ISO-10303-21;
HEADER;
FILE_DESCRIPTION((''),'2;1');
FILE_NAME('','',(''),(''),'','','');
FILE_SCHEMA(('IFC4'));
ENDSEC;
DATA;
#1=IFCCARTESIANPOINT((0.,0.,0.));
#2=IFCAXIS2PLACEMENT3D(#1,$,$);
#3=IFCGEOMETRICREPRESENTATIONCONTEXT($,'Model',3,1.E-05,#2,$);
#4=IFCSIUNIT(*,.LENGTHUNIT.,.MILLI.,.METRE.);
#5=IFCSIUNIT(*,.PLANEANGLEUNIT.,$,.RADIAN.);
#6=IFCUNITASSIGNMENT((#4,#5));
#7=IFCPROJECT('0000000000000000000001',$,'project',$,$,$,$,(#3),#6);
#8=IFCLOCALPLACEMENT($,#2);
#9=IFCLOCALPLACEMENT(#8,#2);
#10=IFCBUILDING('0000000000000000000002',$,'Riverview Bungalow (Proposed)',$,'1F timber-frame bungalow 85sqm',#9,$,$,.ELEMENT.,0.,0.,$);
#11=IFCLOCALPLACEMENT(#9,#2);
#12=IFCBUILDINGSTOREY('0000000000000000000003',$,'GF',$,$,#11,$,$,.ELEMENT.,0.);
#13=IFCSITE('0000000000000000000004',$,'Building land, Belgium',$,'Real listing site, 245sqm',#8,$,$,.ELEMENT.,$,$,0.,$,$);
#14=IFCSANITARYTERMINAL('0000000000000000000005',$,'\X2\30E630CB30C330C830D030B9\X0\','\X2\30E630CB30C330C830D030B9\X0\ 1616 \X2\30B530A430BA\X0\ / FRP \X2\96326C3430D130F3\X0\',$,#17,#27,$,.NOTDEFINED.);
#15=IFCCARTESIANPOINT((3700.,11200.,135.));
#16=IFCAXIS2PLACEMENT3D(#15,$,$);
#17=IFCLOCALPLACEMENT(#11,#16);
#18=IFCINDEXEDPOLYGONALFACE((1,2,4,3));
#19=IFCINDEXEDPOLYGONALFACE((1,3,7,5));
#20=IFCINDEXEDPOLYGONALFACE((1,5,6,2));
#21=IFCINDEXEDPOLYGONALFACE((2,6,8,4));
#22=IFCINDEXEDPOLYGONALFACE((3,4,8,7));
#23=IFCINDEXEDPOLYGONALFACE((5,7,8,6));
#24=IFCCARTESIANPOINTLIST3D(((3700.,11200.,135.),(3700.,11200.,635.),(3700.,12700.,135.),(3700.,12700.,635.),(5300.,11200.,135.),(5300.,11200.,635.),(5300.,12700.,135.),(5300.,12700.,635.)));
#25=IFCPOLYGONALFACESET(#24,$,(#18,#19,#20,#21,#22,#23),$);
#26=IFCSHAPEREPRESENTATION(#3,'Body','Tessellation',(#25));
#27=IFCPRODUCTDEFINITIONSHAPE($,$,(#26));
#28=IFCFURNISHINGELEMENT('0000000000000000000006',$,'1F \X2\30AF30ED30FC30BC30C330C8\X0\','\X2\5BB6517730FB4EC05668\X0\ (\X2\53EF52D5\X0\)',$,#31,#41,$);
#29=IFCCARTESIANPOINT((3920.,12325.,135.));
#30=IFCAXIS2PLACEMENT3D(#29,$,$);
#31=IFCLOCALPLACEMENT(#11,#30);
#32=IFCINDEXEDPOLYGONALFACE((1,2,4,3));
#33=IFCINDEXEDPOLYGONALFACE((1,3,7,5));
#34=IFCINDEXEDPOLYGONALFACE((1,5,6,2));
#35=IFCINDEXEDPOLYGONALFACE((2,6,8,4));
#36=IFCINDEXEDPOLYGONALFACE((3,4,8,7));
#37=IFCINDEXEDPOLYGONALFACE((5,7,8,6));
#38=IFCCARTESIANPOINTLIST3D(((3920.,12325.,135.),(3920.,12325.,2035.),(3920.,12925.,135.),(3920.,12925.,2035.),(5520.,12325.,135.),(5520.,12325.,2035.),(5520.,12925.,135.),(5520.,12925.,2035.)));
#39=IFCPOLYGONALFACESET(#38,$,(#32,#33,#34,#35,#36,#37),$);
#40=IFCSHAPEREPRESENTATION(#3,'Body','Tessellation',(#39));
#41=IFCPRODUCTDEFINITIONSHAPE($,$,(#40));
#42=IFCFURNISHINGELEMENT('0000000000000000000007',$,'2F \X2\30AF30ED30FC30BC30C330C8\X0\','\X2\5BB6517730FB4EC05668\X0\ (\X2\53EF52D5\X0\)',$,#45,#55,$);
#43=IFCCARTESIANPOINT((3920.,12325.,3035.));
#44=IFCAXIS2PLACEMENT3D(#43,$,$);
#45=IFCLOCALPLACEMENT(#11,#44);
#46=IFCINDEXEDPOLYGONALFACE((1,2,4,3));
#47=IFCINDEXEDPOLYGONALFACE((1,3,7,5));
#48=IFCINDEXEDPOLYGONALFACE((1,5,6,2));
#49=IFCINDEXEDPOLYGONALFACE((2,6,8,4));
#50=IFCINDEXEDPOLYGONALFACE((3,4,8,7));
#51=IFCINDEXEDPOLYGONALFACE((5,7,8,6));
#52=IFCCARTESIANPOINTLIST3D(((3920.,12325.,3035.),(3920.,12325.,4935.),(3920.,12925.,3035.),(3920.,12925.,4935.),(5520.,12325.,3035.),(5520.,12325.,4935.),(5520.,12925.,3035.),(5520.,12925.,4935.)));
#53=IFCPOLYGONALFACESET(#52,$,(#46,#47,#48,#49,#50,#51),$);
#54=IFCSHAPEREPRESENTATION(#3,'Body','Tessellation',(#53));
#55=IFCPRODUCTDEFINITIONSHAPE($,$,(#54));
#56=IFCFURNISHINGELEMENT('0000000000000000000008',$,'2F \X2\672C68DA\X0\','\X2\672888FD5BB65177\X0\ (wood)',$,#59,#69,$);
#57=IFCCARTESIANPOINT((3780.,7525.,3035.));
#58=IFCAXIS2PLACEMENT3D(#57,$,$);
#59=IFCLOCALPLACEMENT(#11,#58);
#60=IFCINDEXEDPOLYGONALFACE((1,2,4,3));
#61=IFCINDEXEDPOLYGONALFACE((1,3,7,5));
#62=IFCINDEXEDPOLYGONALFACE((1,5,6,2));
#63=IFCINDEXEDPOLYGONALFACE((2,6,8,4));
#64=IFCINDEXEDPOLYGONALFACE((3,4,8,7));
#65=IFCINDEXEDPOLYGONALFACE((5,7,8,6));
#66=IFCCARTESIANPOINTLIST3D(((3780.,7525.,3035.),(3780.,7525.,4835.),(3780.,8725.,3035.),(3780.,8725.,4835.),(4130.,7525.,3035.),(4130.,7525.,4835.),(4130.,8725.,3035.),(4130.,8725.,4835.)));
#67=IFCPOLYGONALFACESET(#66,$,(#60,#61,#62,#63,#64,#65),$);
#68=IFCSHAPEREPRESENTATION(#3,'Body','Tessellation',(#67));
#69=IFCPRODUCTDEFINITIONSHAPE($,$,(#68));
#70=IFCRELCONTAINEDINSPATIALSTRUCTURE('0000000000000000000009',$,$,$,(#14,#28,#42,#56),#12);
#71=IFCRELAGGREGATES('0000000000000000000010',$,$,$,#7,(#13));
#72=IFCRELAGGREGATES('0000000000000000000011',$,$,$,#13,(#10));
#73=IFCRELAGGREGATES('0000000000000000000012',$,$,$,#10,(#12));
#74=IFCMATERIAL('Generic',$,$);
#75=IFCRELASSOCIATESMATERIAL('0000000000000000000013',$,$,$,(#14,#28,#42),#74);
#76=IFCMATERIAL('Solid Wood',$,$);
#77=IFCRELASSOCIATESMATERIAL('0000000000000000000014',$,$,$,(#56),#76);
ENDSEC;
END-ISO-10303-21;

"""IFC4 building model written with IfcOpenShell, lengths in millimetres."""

from ifc_helpers import new_model, si_unit, frame, frame_2d, origin, place, context, project, spatial, rectangle, extrude, material, element, save


model = new_model("IFC4")

# Units and contexts
model_context = context("Model", 3, precision=1e-05, world=origin())
ifc_project = project(units=[si_unit("LENGTHUNIT", "METRE", prefix="MILLI"), si_unit("PLANEANGLEUNIT", "RADIAN")], contexts=[model_context])

# Site, building, storey
site_placement = place(None, origin())
site = spatial("IfcSite", under=ifc_project, at=site_placement, Name="Building land, Belgium", ObjectType="Real listing site, 245sqm", CompositionType="ELEMENT", RefElevation=0.0)
building_placement = place(site_placement, origin())
building = spatial("IfcBuilding", under=site, at=building_placement, Name="Riverview Bungalow (Proposed)", ObjectType="1F timber-frame bungalow 85sqm", CompositionType="ELEMENT", ElevationOfRefHeight=0.0, ElevationOfTerrain=0.0)
storey_placement = place(building_placement, origin())
storey = spatial("IfcBuildingStorey", under=building, at=storey_placement, Name="GF", CompositionType="ELEMENT", Elevation=0.0)

# Shared definitions
ifc_material_1 = material(Name="Solid Wood")

# Shared definitions
ifc_material_2 = material(Name="Generic")

# Sanitary terminal
sanitary_terminal_placement = place(storey_placement, frame((3700.0, 11200.0, 135.0)))
element("IfcSanitaryTerminal", 1, at=sanitary_terminal_placement, inside=storey, material=ifc_material_2, Name="ユニットバス", Description="ユニットバス 1616 サイズ / FRP 防水パン", PredefinedType="NOTDEFINED", context=model_context, shape_type="SweptSolid", body=[
    extrude(rectangle(XDim=1600.0, YDim=1500.0, at=frame_2d((800.0, 750.0))), frame((3700.0, 11200.0, 135.0)), (0.0, 0.0, 1.0), 500.0),
])

# Furnishing elements
furnishing_1_placement = place(storey_placement, frame((3920.0, 12325.0, 135.0)))
element("IfcFurnishingElement", 2, at=furnishing_1_placement, inside=storey, material=ifc_material_2, Name="1F クローゼット", Description="家具・什器 (可動)", context=model_context, shape_type="SweptSolid", body=[
    extrude(rectangle(XDim=1600.0, YDim=600.0, at=frame_2d((800.0, 300.0))), frame((3920.0, 12325.0, 135.0)), (0.0, 0.0, 1.0), 1900.0),
])
furnishing_2_placement = place(storey_placement, frame((3920.0, 12325.0, 3035.0)))
element("IfcFurnishingElement", 3, at=furnishing_2_placement, inside=storey, material=ifc_material_2, Name="2F クローゼット", Description="家具・什器 (可動)", context=model_context, shape_type="SweptSolid", body=[
    extrude(rectangle(XDim=1600.0, YDim=600.0, at=frame_2d((800.0, 300.0))), frame((3920.0, 12325.0, 3035.0)), (0.0, 0.0, 1.0), 1900.0),
])
furnishing_3_placement = place(storey_placement, frame((3780.0, 7525.0, 3035.0)))
element("IfcFurnishingElement", 4, at=furnishing_3_placement, inside=storey, material=ifc_material_1, Name="2F 本棚", Description="木製家具 (wood)", context=model_context, shape_type="SweptSolid", body=[
    extrude(rectangle(XDim=350.0, YDim=1200.0, at=frame_2d((175.0, 600.0))), frame((3780.0, 7525.0, 3035.0)), (0.0, 0.0, 1.0), 1800.0),
])

save(model, "model.ifc")
